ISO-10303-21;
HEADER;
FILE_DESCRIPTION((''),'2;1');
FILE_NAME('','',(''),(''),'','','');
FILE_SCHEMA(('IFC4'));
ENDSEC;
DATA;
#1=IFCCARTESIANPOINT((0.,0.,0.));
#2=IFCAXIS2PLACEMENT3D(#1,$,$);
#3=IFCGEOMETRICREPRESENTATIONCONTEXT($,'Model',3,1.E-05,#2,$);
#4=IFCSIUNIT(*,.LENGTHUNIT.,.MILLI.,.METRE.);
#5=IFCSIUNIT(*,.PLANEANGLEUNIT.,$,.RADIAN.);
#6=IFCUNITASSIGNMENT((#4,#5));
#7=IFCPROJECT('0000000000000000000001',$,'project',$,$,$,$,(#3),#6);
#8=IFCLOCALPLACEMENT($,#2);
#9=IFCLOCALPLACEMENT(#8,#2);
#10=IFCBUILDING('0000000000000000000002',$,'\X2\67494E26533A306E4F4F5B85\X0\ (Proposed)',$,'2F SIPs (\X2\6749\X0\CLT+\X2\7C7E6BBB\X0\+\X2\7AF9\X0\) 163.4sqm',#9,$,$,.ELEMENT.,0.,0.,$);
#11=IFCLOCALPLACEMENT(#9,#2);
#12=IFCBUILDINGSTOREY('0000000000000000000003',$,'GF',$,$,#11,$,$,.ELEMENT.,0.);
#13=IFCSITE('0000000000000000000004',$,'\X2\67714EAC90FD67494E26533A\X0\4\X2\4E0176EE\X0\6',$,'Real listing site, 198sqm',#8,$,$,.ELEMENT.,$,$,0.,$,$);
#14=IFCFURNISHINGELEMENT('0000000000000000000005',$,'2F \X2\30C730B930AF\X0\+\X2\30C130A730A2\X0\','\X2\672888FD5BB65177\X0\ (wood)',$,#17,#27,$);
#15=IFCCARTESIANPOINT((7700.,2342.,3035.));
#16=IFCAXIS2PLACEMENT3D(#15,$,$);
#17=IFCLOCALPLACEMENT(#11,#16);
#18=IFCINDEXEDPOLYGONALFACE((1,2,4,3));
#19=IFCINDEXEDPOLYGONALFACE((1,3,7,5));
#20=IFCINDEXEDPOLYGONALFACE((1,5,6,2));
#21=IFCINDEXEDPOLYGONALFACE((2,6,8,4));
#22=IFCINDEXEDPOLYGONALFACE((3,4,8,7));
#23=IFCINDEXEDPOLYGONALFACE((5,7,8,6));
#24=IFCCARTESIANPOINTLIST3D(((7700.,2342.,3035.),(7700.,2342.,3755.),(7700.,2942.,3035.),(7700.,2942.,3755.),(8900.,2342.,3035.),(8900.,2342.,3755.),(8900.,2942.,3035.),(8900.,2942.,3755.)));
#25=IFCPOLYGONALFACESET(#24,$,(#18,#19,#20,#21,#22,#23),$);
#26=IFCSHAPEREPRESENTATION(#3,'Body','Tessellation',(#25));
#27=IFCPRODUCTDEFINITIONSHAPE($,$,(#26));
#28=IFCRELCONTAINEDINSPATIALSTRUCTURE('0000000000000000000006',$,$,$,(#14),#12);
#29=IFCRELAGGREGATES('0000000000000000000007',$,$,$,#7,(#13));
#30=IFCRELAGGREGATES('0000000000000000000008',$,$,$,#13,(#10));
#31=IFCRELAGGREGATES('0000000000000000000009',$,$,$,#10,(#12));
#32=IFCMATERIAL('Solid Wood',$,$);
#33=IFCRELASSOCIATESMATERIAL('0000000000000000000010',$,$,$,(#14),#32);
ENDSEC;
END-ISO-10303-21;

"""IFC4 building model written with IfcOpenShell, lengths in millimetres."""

from ifc_helpers import new_model, si_unit, frame, frame_2d, origin, place, context, project, spatial, rectangle, extrude, material, element, save


model = new_model("IFC4")

# Units and contexts
model_context = context("Model", 3, precision=1e-05, world=origin())
ifc_project = project(units=[si_unit("LENGTHUNIT", "METRE", prefix="MILLI"), si_unit("PLANEANGLEUNIT", "RADIAN")], contexts=[model_context])

# Site, building, storey
site_placement = place(None, origin())
site = spatial("IfcSite", under=ifc_project, at=site_placement, Name="東京都杉並区4丁目6", ObjectType="Real listing site, 198sqm", CompositionType="ELEMENT", RefElevation=0.0)
building_placement = place(site_placement, origin())
building = spatial("IfcBuilding", under=site, at=building_placement, Name="杉並区の住宅 (Proposed)", ObjectType="2F SIPs (杉CLT+籾殻+竹) 163.4sqm", CompositionType="ELEMENT", ElevationOfRefHeight=0.0, ElevationOfTerrain=0.0)
storey_placement = place(building_placement, origin())
storey = spatial("IfcBuildingStorey", under=building, at=storey_placement, Name="GF", CompositionType="ELEMENT", Elevation=0.0)

# Shared definitions
ifc_material_1 = material(Name="Solid Wood")

# Furnishing element
furnishing_1_placement = place(storey_placement, frame((7700.0, 2342.0, 3035.0)))
element("IfcFurnishingElement", 1, at=furnishing_1_placement, inside=storey, material=ifc_material_1, Name="2F デスク+チェア", Description="木製家具 (wood)", context=model_context, shape_type="SweptSolid", body=[
    extrude(rectangle(XDim=1200.0, YDim=600.0, at=frame_2d((600.0, 300.0))), frame((7700.0, 2342.0, 3035.0)), (0.0, 0.0, 1.0), 720.0),
])

save(model, "model.ifc")
